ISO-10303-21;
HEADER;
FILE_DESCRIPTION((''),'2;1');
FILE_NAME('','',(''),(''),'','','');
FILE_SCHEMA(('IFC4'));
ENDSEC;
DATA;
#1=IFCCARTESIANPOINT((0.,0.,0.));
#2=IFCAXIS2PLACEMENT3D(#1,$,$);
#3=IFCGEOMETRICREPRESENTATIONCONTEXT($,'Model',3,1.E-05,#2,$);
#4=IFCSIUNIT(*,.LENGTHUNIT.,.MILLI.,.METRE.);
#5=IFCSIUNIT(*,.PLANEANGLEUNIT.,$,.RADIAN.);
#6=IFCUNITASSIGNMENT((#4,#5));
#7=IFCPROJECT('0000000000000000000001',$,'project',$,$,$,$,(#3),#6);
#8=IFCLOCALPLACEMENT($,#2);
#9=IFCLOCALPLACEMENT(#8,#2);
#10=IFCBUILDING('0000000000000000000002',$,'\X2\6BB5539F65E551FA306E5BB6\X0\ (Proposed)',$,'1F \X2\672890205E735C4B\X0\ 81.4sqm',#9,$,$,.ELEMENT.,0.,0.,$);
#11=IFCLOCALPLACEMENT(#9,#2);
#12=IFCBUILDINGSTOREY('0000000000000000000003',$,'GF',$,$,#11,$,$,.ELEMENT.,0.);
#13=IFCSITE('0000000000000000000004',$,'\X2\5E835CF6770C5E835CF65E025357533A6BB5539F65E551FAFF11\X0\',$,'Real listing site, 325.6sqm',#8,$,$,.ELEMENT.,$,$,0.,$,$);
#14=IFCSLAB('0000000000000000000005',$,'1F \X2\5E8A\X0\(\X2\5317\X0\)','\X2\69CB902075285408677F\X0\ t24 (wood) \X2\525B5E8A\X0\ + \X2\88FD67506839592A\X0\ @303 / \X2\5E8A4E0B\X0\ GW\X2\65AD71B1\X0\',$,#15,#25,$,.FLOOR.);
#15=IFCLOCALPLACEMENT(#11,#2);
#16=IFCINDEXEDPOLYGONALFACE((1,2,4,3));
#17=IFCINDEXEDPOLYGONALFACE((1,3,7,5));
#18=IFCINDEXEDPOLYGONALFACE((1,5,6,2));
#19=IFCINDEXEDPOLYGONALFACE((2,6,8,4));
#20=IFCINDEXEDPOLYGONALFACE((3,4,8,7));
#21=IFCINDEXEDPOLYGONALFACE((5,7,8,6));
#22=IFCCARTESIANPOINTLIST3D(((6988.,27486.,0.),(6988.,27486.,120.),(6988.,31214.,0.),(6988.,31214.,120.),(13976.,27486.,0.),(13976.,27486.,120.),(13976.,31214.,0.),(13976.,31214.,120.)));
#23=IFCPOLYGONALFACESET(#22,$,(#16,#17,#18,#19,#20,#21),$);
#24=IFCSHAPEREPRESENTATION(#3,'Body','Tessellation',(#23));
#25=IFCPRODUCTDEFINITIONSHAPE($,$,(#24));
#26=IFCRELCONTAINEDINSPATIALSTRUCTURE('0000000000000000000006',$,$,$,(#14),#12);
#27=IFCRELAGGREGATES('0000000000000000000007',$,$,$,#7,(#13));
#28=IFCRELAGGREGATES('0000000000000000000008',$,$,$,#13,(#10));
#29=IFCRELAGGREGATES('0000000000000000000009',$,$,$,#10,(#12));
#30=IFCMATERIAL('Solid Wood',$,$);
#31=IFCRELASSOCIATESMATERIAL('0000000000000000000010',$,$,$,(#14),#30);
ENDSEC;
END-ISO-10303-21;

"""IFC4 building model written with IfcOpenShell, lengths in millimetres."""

from ifc_helpers import new_model, si_unit, frame, frame_2d, origin, place, context, project, spatial, rectangle, extrude, material, element, save


model = new_model("IFC4")

# Units and contexts
model_context = context("Model", 3, precision=1e-05, world=origin())
ifc_project = project(units=[si_unit("LENGTHUNIT", "METRE", prefix="MILLI"), si_unit("PLANEANGLEUNIT", "RADIAN")], contexts=[model_context])

# Site, building, storey
site_placement = place(None, origin())
site = spatial("IfcSite", under=ifc_project, at=site_placement, Name="広島県広島市南区段原日出１", ObjectType="Real listing site, 325.6sqm", CompositionType="ELEMENT", RefElevation=0.0)
building_placement = place(site_placement, origin())
building = spatial("IfcBuilding", under=site, at=building_placement, Name="段原日出の家 (Proposed)", ObjectType="1F 木造平屋 81.4sqm", CompositionType="ELEMENT", ElevationOfRefHeight=0.0, ElevationOfTerrain=0.0)
storey_placement = place(building_placement, origin())
storey = spatial("IfcBuildingStorey", under=building, at=storey_placement, Name="GF", CompositionType="ELEMENT", Elevation=0.0)

# Slab
ifc_material_1 = material(Name="Solid Wood")
slab_1_placement = place(storey_placement, frame((3494.0, 13743.0, 0.0)))
element("IfcSlab", 1, at=slab_1_placement, inside=storey, material=ifc_material_1, Name="1F 床(北)", Description="構造用合板 t24 (wood) 剛床 + 製材根太 @303 / 床下 GW断熱", PredefinedType="FLOOR", context=model_context, shape_type="SweptSolid", body=[
    extrude(rectangle(XDim=6988.0, YDim=3728.0, at=frame_2d((3494.0, 1864.0))), frame((3494.0, 13743.0, 0.0)), (0.0, 0.0, 1.0), 120.0),
])

save(model, "model.ifc")
